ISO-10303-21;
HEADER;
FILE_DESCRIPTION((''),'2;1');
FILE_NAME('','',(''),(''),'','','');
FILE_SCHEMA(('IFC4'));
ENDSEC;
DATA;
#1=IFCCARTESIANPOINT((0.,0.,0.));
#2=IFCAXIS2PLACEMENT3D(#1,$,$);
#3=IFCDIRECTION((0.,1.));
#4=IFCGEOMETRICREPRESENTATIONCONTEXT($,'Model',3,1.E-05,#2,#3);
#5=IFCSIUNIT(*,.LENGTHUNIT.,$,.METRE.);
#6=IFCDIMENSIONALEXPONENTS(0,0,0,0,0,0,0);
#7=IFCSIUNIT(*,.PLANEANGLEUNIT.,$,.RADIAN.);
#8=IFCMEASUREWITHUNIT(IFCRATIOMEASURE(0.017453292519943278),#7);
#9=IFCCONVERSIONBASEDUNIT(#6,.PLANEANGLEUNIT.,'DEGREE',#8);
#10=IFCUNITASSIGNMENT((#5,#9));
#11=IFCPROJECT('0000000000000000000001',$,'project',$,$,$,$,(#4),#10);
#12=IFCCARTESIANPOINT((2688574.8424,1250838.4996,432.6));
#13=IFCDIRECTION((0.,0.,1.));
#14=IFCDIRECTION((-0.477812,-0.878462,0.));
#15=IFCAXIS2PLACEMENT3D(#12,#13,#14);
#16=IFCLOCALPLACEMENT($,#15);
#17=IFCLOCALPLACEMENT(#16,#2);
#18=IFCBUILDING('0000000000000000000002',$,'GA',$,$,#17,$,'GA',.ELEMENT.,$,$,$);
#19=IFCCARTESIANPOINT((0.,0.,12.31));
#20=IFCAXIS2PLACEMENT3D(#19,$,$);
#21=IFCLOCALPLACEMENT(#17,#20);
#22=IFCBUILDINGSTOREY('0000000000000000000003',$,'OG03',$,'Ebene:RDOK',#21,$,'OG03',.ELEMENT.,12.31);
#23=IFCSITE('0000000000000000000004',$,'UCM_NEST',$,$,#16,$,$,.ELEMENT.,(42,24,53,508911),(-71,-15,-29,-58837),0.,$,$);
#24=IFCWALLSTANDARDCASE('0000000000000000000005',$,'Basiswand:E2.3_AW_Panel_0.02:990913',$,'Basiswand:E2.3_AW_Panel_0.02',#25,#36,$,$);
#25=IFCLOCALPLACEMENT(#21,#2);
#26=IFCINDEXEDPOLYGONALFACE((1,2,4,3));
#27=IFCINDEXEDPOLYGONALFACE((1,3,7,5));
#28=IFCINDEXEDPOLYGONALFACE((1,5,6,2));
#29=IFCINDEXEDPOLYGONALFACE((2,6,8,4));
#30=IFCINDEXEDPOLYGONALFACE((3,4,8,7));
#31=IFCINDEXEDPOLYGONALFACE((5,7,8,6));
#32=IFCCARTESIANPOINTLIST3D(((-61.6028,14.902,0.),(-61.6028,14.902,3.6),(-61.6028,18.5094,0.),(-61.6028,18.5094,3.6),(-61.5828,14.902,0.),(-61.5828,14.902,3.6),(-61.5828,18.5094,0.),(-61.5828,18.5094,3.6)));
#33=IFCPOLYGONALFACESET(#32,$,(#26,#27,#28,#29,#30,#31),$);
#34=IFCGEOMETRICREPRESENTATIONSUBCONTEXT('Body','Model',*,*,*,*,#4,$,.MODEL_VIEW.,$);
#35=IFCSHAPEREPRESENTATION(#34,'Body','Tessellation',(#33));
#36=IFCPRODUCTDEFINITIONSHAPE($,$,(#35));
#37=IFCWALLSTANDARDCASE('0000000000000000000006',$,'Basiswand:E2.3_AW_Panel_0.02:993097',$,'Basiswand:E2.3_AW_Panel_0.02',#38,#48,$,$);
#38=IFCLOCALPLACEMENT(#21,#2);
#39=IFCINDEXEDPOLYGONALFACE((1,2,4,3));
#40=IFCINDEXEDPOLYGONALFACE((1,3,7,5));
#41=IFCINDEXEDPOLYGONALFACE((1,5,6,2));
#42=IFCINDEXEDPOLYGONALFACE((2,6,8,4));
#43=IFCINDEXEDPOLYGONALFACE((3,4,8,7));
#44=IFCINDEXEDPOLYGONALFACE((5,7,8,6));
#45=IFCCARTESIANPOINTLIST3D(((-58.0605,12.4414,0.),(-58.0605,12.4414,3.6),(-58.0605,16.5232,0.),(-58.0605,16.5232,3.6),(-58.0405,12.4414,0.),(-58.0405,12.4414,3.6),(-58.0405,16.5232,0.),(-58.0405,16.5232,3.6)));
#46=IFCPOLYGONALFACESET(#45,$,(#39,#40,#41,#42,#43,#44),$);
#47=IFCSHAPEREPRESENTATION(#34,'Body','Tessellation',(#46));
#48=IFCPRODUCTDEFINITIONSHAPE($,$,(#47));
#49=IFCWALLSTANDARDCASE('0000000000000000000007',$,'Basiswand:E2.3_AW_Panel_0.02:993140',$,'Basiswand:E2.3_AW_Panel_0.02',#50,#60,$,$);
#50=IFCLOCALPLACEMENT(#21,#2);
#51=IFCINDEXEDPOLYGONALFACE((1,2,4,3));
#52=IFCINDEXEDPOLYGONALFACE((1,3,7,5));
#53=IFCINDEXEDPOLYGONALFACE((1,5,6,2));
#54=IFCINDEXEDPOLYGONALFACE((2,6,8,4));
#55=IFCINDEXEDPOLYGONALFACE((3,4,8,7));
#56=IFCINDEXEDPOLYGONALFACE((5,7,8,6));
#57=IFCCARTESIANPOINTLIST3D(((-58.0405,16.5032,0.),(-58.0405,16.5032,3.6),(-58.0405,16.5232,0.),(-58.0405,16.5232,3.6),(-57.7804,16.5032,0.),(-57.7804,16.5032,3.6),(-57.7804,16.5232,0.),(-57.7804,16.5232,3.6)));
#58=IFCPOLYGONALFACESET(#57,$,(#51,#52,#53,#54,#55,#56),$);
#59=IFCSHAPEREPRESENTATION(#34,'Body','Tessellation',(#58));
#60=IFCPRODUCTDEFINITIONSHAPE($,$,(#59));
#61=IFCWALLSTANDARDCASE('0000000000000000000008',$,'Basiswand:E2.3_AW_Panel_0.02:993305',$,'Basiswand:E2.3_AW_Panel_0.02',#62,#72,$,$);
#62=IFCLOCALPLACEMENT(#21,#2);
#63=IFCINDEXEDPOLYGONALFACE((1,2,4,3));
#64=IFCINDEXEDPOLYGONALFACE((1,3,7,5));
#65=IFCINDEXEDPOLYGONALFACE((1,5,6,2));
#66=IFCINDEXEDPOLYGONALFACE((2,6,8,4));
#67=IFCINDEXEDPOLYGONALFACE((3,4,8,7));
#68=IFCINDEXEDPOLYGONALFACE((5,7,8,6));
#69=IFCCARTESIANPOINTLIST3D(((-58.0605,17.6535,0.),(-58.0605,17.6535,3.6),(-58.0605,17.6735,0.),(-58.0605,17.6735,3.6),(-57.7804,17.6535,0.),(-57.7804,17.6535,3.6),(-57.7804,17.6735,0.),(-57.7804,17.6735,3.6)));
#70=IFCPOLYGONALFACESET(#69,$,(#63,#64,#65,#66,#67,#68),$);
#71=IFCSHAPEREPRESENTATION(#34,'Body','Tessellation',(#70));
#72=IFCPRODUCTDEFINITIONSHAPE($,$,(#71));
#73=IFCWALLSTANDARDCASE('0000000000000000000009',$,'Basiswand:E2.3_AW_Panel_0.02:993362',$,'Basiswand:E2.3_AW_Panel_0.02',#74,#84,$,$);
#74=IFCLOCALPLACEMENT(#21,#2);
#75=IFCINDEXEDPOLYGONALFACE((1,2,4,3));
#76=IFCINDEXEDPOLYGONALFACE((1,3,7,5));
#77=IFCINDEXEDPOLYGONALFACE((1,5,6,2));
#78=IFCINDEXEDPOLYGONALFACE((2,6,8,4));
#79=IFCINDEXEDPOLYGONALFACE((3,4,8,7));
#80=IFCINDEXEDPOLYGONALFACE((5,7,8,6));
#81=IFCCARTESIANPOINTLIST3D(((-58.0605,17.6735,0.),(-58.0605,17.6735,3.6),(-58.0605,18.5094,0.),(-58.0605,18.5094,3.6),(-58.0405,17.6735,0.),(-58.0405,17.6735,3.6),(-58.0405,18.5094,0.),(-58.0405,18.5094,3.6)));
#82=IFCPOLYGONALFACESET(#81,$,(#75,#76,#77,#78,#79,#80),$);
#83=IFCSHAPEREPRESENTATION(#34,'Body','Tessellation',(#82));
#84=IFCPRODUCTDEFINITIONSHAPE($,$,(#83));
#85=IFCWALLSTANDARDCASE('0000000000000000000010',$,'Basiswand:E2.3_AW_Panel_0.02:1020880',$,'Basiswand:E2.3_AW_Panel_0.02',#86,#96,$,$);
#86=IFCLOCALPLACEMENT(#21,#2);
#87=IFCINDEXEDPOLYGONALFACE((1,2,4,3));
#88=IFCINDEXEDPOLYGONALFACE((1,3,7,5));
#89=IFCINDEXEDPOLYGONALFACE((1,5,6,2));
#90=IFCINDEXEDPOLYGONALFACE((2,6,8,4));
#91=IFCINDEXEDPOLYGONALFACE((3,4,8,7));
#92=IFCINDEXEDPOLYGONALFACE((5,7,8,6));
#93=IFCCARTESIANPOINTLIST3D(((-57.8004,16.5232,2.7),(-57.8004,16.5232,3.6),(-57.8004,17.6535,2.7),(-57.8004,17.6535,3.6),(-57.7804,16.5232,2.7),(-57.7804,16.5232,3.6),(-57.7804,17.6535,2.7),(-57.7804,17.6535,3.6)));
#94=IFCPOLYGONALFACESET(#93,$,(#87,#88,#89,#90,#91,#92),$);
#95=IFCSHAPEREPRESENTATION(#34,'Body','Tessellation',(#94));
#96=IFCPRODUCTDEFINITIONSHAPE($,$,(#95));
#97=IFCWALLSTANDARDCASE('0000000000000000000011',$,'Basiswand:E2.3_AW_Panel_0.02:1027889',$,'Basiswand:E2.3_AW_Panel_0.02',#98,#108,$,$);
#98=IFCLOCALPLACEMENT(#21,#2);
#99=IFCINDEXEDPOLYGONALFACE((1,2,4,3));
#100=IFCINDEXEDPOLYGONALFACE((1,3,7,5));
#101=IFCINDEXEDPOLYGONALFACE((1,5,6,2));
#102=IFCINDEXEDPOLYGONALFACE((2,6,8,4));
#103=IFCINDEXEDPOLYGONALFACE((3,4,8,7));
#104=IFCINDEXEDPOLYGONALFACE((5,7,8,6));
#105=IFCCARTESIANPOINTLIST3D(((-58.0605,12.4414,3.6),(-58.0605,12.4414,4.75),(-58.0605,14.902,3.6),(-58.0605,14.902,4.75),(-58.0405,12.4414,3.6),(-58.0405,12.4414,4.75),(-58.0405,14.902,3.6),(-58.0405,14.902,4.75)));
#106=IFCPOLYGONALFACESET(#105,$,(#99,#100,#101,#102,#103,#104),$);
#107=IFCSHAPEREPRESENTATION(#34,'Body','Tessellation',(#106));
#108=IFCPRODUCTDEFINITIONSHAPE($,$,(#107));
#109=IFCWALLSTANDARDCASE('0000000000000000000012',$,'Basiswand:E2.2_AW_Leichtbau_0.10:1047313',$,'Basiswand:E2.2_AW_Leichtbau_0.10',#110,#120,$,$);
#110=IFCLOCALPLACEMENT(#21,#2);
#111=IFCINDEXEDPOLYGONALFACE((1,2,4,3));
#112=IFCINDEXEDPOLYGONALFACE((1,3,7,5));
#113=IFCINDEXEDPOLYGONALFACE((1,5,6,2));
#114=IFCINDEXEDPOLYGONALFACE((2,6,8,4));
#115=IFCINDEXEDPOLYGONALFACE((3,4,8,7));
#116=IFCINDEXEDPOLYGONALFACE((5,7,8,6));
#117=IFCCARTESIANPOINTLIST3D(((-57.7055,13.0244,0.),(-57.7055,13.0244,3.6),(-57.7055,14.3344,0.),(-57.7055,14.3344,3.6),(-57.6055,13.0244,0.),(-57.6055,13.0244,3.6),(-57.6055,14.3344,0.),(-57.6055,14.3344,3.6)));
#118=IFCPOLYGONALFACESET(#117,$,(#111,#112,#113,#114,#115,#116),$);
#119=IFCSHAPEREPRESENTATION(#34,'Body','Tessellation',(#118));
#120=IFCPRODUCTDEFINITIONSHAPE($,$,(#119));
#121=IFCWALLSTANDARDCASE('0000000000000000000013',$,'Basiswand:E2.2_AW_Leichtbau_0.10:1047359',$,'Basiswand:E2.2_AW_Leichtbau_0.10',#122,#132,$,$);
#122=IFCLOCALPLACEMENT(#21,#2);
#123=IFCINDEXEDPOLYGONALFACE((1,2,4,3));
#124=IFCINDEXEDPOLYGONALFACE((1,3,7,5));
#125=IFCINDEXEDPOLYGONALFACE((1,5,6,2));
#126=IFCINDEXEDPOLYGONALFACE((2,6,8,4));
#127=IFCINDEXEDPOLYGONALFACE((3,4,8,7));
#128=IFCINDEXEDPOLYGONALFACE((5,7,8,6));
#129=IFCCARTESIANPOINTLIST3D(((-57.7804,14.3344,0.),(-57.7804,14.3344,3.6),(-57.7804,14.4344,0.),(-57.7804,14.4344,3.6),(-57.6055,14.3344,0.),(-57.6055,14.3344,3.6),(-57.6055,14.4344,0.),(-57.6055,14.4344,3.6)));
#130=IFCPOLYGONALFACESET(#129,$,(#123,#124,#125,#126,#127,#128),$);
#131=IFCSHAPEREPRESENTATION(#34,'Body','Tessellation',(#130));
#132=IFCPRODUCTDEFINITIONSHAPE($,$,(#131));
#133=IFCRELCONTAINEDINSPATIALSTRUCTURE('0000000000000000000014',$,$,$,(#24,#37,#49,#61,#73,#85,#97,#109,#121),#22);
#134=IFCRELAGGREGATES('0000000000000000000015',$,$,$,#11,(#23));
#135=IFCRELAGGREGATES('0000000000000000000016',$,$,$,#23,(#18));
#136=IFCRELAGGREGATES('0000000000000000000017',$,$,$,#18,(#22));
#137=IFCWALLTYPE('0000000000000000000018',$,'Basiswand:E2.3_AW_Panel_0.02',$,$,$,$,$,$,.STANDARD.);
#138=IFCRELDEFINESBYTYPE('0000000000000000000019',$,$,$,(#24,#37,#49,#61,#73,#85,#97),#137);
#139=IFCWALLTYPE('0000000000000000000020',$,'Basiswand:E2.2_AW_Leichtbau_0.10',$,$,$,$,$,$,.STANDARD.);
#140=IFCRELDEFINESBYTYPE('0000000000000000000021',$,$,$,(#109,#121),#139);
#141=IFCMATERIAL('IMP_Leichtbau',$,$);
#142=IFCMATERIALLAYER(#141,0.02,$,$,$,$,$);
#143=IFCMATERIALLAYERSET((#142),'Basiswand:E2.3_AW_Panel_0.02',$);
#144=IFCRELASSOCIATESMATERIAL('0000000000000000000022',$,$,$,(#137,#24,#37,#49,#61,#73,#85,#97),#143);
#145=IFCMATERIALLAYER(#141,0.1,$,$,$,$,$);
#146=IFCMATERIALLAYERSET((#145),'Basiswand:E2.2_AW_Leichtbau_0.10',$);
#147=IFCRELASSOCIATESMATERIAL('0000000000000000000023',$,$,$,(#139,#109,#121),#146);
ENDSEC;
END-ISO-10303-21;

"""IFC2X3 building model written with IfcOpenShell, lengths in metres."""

from ifc_helpers import new_model, entity, si_unit, converted_unit, direction, frame, frame_2d, origin, place, context, subcontext, project, spatial, rectangle, extrude, material, layer, layer_set, layer_usage, type_object, element, save


model = new_model("IFC2X3")

# Units and contexts
model_context = context("Model", 3, precision=1e-05, world=origin(), true_north=direction((0.0, 1.0)))
body_context = subcontext(model_context, "Body", "Model", "MODEL_VIEW")
ifc_project = project(units=[si_unit("LENGTHUNIT", "METRE"), converted_unit("PLANEANGLEUNIT", "DEGREE", entity("IfcRatioMeasure", 0.017453292519943278), si_unit("PLANEANGLEUNIT", "RADIAN"), dimensions=[0, 0, 0, 0, 0, 0, 0])], contexts=[model_context])

# Site, building, storey
site_placement = place(None, frame((2688574.8424, 1250838.4996, 432.6), z_axis=(0.0, 0.0, 1.0), x_axis=(-0.477812, -0.878462, 0.0)))
site = spatial("IfcSite", under=ifc_project, at=site_placement, Name="UCM_NEST", CompositionType="ELEMENT", RefLatitude=(42, 24, 53, 508911), RefLongitude=(-71, -15, -29, -58837), RefElevation=0.0)
building_placement = place(site_placement, origin())
building = spatial("IfcBuilding", under=site, at=building_placement, Name="GA", LongName="GA", CompositionType="ELEMENT")
storey_placement = place(building_placement, frame((0.0, 0.0, 12.31)))
storey = spatial("IfcBuildingStorey", under=building, at=storey_placement, Name="OG03", ObjectType="Ebene:RDOK", LongName="OG03", CompositionType="ELEMENT", Elevation=12.31)

# Shared definitions
ifc_material_1 = material(Name="IMP_Leichtbau")

# Walls
ifc_layer_1 = layer(ifc_material_1, 0.02)
ifc_layer_set_1 = layer_set([ifc_layer_1], Name="Basiswand:E2.3_AW_Panel_0.02")
ifc_layer_usage_1 = layer_usage(ifc_layer_set_1, "AXIS2", "NEGATIVE", 0.01)
wall_type_1 = type_object("IfcWallType", Name="Basiswand:E2.3_AW_Panel_0.02", PredefinedType="STANDARD", material=ifc_layer_set_1)
wall_1_placement = place(storey_placement, frame((-61.5928, 18.5094, 0.0), z_axis=(0.0, 0.0, 1.0), x_axis=(0.0, -1.0, 0.0)))
element("IfcWallStandardCase", 1, at=wall_1_placement, inside=storey, type_object=wall_type_1, material=ifc_layer_usage_1, Name="Basiswand:E2.3_AW_Panel_0.02:990913", ObjectType="Basiswand:E2.3_AW_Panel_0.02", context=body_context, shape_type="SweptSolid", body=[
    extrude(rectangle(XDim=3.6075, YDim=0.02, at=frame_2d((1.8037, 0.0), x_axis=(-1.0, 0.0))), origin(), (0.0, 0.0, 1.0), 3.6),
])
wall_2_placement = place(storey_placement, frame((-58.0505, 12.4414, 0.0), z_axis=(0.0, 0.0, 1.0), x_axis=(0.0, 1.0, 0.0)))
element("IfcWallStandardCase", 2, at=wall_2_placement, inside=storey, type_object=wall_type_1, material=ifc_layer_usage_1, Name="Basiswand:E2.3_AW_Panel_0.02:993097", ObjectType="Basiswand:E2.3_AW_Panel_0.02", context=body_context, shape_type="SweptSolid", body=[
    extrude(rectangle(XDim=4.0818, YDim=0.02, at=frame_2d((2.0409, 0.0), x_axis=(-1.0, 0.0))), origin(), (0.0, 0.0, 1.0), 3.6),
])
wall_3_placement = place(storey_placement, frame((-58.0405, 16.5132, 0.0)))
element("IfcWallStandardCase", 3, at=wall_3_placement, inside=storey, type_object=wall_type_1, material=ifc_layer_usage_1, Name="Basiswand:E2.3_AW_Panel_0.02:993140", ObjectType="Basiswand:E2.3_AW_Panel_0.02", context=body_context, shape_type="SweptSolid", body=[
    extrude(rectangle(XDim=0.2601, YDim=0.02, at=frame_2d((0.13, 0.0), x_axis=(-1.0, 0.0))), origin(), (0.0, 0.0, 1.0), 3.6),
])
wall_4_placement = place(storey_placement, frame((-57.7804, 17.6635, 0.0), z_axis=(0.0, 0.0, 1.0), x_axis=(-1.0, 0.0, 0.0)))
element("IfcWallStandardCase", 4, at=wall_4_placement, inside=storey, type_object=wall_type_1, material=ifc_layer_usage_1, Name="Basiswand:E2.3_AW_Panel_0.02:993305", ObjectType="Basiswand:E2.3_AW_Panel_0.02", context=body_context, shape_type="SweptSolid", body=[
    extrude(rectangle(XDim=0.2801, YDim=0.02, at=frame_2d((0.14, 0.0), x_axis=(-1.0, 0.0))), origin(), (0.0, 0.0, 1.0), 3.6),
])
wall_5_placement = place(storey_placement, frame((-58.0505, 17.6735, 0.0), z_axis=(0.0, 0.0, 1.0), x_axis=(0.0, 1.0, 0.0)))
element("IfcWallStandardCase", 5, at=wall_5_placement, inside=storey, type_object=wall_type_1, material=ifc_layer_usage_1, Name="Basiswand:E2.3_AW_Panel_0.02:993362", ObjectType="Basiswand:E2.3_AW_Panel_0.02", context=body_context, shape_type="SweptSolid", body=[
    extrude(rectangle(XDim=0.836, YDim=0.02, at=frame_2d((0.418, 0.0), x_axis=(-1.0, 0.0))), origin(), (0.0, 0.0, 1.0), 3.6),
])
wall_6_placement = place(storey_placement, frame((-57.7904, 16.5232, 2.7), z_axis=(0.0, 0.0, 1.0), x_axis=(0.0, 1.0, 0.0)))
element("IfcWallStandardCase", 6, at=wall_6_placement, inside=storey, type_object=wall_type_1, material=ifc_layer_usage_1, Name="Basiswand:E2.3_AW_Panel_0.02:1020880", ObjectType="Basiswand:E2.3_AW_Panel_0.02", context=body_context, shape_type="SweptSolid", body=[
    extrude(rectangle(XDim=1.1302, YDim=0.02, at=frame_2d((0.5651, 0.0), x_axis=(-1.0, 0.0))), origin(), (0.0, 0.0, 1.0), 0.9),
])
wall_7_placement = place(storey_placement, frame((-58.0505, 14.902, 3.6), z_axis=(0.0, 0.0, 1.0), x_axis=(0.0, -1.0, 0.0)))
element("IfcWallStandardCase", 7, at=wall_7_placement, inside=storey, type_object=wall_type_1, material=ifc_layer_usage_1, Name="Basiswand:E2.3_AW_Panel_0.02:1027889", ObjectType="Basiswand:E2.3_AW_Panel_0.02", context=body_context, shape_type="SweptSolid", body=[
    extrude(rectangle(XDim=2.4605, YDim=0.02, at=frame_2d((1.2303, 0.0), x_axis=(-1.0, 0.0))), origin(), (0.0, 0.0, 1.0), 1.15),
])

# Walls
ifc_layer_2 = layer(ifc_material_1, 0.1)
ifc_layer_set_2 = layer_set([ifc_layer_2], Name="Basiswand:E2.2_AW_Leichtbau_0.10")
ifc_layer_usage_2 = layer_usage(ifc_layer_set_2, "AXIS2", "NEGATIVE", 0.05)
wall_type_2 = type_object("IfcWallType", Name="Basiswand:E2.2_AW_Leichtbau_0.10", PredefinedType="STANDARD", material=ifc_layer_set_2)
wall_8_placement = place(storey_placement, frame((-57.6555, 13.0244, 0.0), z_axis=(0.0, 0.0, 1.0), x_axis=(0.0, 1.0, 0.0)))
element("IfcWallStandardCase", 8, at=wall_8_placement, inside=storey, type_object=wall_type_2, material=ifc_layer_usage_2, Name="Basiswand:E2.2_AW_Leichtbau_0.10:1047313", ObjectType="Basiswand:E2.2_AW_Leichtbau_0.10", context=body_context, shape_type="SweptSolid", body=[
    extrude(rectangle(XDim=1.31, YDim=0.1, at=frame_2d((0.655, 0.0), x_axis=(-1.0, 0.0))), origin(), (0.0, 0.0, 1.0), 3.6),
])
wall_9_placement = place(storey_placement, frame((-57.6055, 14.3844, 0.0), z_axis=(0.0, 0.0, 1.0), x_axis=(-1.0, 0.0, 0.0)))
element("IfcWallStandardCase", 9, at=wall_9_placement, inside=storey, type_object=wall_type_2, material=ifc_layer_usage_2, Name="Basiswand:E2.2_AW_Leichtbau_0.10:1047359", ObjectType="Basiswand:E2.2_AW_Leichtbau_0.10", context=body_context, shape_type="SweptSolid", body=[
    extrude(rectangle(XDim=0.175, YDim=0.1, at=frame_2d((0.0875, 0.0), x_axis=(-1.0, 0.0))), origin(), (0.0, 0.0, 1.0), 3.6),
])

save(model, "model.ifc")
